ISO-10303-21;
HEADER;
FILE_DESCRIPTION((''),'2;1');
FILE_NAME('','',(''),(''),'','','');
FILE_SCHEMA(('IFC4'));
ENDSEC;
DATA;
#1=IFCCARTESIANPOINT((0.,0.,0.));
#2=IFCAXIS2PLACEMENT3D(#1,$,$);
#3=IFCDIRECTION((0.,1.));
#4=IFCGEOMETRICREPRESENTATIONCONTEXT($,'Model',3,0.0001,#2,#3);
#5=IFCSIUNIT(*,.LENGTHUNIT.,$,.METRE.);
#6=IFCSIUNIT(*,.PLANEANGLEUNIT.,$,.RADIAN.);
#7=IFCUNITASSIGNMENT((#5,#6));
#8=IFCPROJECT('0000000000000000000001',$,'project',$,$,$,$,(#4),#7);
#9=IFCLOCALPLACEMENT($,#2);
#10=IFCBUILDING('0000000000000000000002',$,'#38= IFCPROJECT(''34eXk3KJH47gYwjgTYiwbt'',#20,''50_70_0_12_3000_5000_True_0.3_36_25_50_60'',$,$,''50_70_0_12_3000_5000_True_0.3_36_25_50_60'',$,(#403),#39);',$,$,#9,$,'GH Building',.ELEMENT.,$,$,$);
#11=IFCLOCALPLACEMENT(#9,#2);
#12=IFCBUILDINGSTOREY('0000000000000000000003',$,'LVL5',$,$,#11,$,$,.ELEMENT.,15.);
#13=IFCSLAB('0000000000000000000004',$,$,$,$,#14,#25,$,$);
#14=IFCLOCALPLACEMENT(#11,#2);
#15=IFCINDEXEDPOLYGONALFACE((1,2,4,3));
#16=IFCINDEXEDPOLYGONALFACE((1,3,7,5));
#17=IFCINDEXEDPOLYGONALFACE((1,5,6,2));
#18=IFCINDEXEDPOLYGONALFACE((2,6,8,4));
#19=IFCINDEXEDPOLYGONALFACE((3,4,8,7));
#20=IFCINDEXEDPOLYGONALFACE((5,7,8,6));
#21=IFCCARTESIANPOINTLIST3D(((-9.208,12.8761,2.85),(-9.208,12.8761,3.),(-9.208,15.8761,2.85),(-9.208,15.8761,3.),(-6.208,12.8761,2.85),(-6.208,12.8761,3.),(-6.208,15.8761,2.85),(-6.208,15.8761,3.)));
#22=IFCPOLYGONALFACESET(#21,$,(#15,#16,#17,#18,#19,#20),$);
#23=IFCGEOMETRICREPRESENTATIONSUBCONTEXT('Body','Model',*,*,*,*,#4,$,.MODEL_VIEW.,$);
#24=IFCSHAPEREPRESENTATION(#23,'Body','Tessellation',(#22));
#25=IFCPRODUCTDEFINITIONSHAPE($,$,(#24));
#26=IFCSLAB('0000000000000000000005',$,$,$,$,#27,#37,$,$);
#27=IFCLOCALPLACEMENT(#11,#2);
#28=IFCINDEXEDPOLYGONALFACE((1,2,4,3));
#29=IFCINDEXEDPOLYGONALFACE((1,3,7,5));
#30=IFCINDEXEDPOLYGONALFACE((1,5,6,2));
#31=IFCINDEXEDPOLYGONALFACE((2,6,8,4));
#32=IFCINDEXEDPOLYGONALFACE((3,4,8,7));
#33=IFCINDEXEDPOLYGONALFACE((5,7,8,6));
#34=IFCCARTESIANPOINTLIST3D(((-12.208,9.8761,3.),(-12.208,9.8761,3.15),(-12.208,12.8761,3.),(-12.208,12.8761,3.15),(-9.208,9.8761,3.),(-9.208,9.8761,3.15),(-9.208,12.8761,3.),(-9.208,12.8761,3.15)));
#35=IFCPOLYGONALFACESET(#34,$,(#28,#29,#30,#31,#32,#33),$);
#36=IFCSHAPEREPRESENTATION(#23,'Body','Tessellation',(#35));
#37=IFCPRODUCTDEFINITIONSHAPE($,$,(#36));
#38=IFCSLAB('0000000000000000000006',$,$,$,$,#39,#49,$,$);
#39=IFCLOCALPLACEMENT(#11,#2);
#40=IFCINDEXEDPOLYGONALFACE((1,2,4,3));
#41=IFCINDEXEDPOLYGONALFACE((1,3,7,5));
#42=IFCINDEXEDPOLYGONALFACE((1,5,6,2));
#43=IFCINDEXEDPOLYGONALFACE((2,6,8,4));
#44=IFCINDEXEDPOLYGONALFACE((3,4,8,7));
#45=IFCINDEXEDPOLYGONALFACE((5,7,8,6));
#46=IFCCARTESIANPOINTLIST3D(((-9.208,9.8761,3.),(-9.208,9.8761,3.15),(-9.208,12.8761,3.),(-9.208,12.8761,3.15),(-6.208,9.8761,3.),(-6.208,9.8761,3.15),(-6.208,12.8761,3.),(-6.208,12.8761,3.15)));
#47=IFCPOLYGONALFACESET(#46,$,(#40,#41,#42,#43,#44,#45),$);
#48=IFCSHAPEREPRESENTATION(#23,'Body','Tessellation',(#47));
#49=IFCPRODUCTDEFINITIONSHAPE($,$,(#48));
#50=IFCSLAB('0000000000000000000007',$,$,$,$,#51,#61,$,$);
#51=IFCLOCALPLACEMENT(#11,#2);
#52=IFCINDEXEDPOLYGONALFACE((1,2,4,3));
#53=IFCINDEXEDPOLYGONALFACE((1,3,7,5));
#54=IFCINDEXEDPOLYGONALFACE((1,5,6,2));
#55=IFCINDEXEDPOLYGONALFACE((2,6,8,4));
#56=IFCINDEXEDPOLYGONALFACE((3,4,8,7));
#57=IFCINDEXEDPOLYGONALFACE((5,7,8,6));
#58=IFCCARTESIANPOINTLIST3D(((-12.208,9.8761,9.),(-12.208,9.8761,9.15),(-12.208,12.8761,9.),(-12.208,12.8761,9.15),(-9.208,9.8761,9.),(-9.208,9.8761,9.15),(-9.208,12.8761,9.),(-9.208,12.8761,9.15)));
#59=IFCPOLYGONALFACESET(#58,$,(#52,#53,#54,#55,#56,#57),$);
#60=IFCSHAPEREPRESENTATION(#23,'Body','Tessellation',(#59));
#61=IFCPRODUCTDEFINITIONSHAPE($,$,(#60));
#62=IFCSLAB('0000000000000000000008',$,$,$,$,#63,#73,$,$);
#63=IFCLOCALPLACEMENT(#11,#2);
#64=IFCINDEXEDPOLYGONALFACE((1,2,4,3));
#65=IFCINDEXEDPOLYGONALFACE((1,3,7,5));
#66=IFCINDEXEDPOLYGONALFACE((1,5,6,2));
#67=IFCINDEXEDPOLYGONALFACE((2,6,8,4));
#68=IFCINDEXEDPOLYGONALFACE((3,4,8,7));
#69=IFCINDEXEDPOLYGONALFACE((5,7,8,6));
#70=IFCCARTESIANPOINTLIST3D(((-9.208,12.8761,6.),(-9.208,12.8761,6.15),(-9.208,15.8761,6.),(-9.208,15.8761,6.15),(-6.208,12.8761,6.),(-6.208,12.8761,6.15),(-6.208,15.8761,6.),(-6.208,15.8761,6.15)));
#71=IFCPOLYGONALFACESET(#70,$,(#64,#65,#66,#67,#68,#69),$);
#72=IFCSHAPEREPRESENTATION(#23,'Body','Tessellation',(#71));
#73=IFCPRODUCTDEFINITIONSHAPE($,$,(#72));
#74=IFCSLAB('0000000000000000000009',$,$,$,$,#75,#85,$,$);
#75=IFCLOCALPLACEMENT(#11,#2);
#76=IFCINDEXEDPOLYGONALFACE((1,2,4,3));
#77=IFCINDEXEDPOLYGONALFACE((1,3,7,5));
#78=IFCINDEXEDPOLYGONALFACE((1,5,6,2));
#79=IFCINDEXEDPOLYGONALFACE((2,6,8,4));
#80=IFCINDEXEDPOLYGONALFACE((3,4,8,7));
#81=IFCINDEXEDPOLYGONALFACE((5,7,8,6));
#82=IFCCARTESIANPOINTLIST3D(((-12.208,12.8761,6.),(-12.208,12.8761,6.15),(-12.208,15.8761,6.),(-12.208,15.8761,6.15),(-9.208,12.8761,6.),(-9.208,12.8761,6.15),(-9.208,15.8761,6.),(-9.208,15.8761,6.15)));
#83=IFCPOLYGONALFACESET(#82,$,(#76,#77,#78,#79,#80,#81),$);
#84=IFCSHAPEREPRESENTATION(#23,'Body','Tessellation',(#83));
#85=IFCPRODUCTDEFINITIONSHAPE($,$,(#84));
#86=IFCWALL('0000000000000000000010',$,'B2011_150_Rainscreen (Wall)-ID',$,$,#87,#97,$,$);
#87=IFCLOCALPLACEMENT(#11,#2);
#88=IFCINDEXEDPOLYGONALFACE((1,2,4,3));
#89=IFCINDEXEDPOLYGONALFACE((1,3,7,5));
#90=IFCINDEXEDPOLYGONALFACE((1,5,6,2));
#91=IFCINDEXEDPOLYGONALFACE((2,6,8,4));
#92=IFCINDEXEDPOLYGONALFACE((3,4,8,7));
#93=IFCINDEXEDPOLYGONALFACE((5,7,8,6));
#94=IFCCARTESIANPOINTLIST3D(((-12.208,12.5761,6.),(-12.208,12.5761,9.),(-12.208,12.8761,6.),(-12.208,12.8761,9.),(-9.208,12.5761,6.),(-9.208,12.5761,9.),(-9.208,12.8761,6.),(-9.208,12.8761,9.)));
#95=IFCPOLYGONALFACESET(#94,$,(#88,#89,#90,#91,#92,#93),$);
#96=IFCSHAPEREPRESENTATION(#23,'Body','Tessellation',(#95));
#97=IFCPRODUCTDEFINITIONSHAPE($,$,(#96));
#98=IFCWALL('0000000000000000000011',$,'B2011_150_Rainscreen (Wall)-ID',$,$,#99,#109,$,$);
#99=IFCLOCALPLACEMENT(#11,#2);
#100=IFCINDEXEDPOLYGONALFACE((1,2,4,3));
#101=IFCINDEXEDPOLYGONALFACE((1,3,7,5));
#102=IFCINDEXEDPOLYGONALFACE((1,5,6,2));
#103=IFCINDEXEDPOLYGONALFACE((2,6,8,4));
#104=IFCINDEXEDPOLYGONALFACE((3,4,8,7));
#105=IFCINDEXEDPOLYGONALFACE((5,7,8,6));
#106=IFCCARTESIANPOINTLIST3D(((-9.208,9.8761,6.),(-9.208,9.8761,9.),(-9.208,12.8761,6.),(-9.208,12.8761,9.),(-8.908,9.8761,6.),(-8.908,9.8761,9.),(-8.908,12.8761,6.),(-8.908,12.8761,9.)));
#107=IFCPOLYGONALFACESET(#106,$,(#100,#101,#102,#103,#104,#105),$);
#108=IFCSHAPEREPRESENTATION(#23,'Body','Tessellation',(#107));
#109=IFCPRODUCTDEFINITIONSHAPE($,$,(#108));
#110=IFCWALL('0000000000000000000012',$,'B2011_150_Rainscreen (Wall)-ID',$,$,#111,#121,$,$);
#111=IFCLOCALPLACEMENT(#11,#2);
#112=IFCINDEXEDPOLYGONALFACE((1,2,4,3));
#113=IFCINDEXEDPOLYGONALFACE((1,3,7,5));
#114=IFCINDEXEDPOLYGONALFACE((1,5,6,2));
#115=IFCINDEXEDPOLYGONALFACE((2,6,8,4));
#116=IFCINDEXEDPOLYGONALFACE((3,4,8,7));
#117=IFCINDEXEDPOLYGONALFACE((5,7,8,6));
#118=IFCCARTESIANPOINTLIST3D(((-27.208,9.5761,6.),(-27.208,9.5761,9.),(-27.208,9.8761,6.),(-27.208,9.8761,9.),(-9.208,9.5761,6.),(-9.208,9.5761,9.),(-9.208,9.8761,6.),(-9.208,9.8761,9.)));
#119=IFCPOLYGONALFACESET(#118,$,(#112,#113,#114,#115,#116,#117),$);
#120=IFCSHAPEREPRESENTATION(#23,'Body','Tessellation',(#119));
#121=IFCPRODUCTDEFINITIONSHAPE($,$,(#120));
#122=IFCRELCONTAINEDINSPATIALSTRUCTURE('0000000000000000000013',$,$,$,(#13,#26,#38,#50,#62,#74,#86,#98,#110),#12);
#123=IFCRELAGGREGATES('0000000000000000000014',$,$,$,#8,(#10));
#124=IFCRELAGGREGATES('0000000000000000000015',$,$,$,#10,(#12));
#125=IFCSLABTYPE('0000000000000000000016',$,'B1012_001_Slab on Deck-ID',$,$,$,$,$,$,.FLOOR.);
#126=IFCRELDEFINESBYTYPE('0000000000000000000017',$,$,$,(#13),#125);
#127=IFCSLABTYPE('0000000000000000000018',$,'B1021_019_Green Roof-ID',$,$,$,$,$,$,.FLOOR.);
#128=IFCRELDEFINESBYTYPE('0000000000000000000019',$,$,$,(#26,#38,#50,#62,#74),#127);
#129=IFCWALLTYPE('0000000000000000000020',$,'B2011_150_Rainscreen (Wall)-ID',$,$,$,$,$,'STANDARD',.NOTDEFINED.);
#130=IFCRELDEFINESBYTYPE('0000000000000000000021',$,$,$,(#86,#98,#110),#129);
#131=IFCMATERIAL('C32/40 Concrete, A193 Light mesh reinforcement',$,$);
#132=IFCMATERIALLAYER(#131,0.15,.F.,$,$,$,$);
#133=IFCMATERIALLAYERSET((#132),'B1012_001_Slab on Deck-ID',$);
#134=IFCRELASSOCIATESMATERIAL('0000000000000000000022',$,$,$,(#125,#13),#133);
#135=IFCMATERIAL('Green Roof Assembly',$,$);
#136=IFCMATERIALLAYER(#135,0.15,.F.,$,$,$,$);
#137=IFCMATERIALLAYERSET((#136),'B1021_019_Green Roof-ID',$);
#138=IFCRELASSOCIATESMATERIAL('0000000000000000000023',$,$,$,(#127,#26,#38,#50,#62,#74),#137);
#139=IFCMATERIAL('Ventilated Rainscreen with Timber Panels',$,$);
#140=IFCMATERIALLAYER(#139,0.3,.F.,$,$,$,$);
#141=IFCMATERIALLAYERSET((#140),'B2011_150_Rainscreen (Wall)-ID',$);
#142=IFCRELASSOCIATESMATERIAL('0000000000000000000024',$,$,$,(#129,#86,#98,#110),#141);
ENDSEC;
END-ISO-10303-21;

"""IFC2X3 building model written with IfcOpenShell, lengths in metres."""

from ifc_helpers import new_model, si_unit, direction, frame, frame_2d, origin, place, context, subcontext, project, spatial, polyline, rectangle, outline, extrude, material, layer, layer_set, layer_usage, type_object, element, save


model = new_model("IFC2X3")

# Units and contexts
model_context = context("Model", 3, precision=0.0001, world=origin(), true_north=direction((0.0, 1.0)))
body_context = subcontext(model_context, "Body", "Model", "MODEL_VIEW")
ifc_project = project(units=[si_unit("LENGTHUNIT", "METRE"), si_unit("PLANEANGLEUNIT", "RADIAN")], contexts=[model_context])

# Building, storey
building_placement = place(None, origin())
building = spatial("IfcBuilding", under=ifc_project, at=building_placement, Name="#38= IFCPROJECT('34eXk3KJH47gYwjgTYiwbt',#20,'50_70_0_12_3000_5000_True_0.3_36_25_50_60',$,$,'50_70_0_12_3000_5000_True_0.3_36_25_50_60',$,(#403),#39);", LongName="GH Building", CompositionType="ELEMENT")
storey_placement = place(building_placement, origin())
storey = spatial("IfcBuildingStorey", under=building, at=storey_placement, Name="LVL5", CompositionType="ELEMENT", Elevation=15.0)

# Slabs
ifc_material_1 = material(Name="C32/40 Concrete, A193 Light mesh reinforcement")
ifc_layer_1 = layer(ifc_material_1, 0.15, ventilated=False)
ifc_layer_set_1 = layer_set([ifc_layer_1], Name="B1012_001_Slab on Deck-ID")
slab_type_1 = type_object("IfcSlabType", Name="B1012_001_Slab on Deck-ID", PredefinedType="FLOOR", material=ifc_layer_set_1)
ifc_layer_usage_1 = layer_usage(ifc_layer_set_1, "AXIS3", "NEGATIVE", -0.15)
slab_1_placement = place(storey_placement, frame((-7.708, 14.3761, 2.85), z_axis=(0.0, 0.0, 1.0), x_axis=(0.0, 1.0, 0.0)))
element("IfcSlab", 1, at=slab_1_placement, inside=storey, type_object=slab_type_1, material=ifc_layer_usage_1, context=body_context, shape_type="SweptSolid", body=[
    extrude(outline(polyline([(-1.5, -1.5), (1.5, -1.5), (1.5, 1.5), (-1.5, 1.5), (-1.5, -1.5)])), origin(), (0.0, 0.0, 1.0), 0.15),
])
ifc_material_2 = material(Name="Green Roof Assembly")
ifc_layer_2 = layer(ifc_material_2, 0.15, ventilated=False)
ifc_layer_set_2 = layer_set([ifc_layer_2], Name="B1021_019_Green Roof-ID")
ifc_layer_usage_2 = layer_usage(ifc_layer_set_2, "AXIS3", "NEGATIVE", -0.15)
slab_type_2 = type_object("IfcSlabType", Name="B1021_019_Green Roof-ID", PredefinedType="FLOOR", material=ifc_layer_set_2)
slab_2_placement = place(storey_placement, frame((-10.708, 11.3761, 3.0), z_axis=(0.0, 0.0, 1.0), x_axis=(0.0, 1.0, 0.0)))
element("IfcSlab", 2, at=slab_2_placement, inside=storey, type_object=slab_type_2, material=ifc_layer_usage_2, context=body_context, shape_type="SweptSolid", body=[
    extrude(outline(polyline([(-1.5, -1.5), (1.5, -1.5), (1.5, 1.5), (-1.5, 1.5), (-1.5, -1.5)])), origin(), (0.0, 0.0, 1.0), 0.15),
])
ifc_layer_usage_3 = layer_usage(ifc_layer_set_2, "AXIS3", "NEGATIVE", -0.15)
slab_3_placement = place(storey_placement, frame((-7.708, 11.3761, 3.0), z_axis=(0.0, 0.0, 1.0), x_axis=(0.0, 1.0, 0.0)))
element("IfcSlab", 3, at=slab_3_placement, inside=storey, type_object=slab_type_2, material=ifc_layer_usage_3, context=body_context, shape_type="SweptSolid", body=[
    extrude(outline(polyline([(-1.5, -1.5), (1.5, -1.5), (1.5, 1.5), (-1.5, 1.5), (-1.5, -1.5)])), origin(), (0.0, 0.0, 1.0), 0.15),
])
ifc_layer_usage_4 = layer_usage(ifc_layer_set_2, "AXIS3", "NEGATIVE", -0.15)
slab_4_placement = place(storey_placement, frame((-10.708, 11.3761, 9.0)))
element("IfcSlab", 4, at=slab_4_placement, inside=storey, type_object=slab_type_2, material=ifc_layer_usage_4, context=body_context, shape_type="SweptSolid", body=[
    extrude(outline(polyline([(1.5, -1.5), (-1.5, -1.5), (-1.5, 1.5), (1.5, 1.5), (1.5, -1.5)])), origin(), (0.0, 0.0, 1.0), 0.15),
])
ifc_layer_usage_5 = layer_usage(ifc_layer_set_2, "AXIS3", "NEGATIVE", -0.15)
slab_5_placement = place(storey_placement, frame((-7.708, 14.3761, 6.0)))
element("IfcSlab", 5, at=slab_5_placement, inside=storey, type_object=slab_type_2, material=ifc_layer_usage_5, context=body_context, shape_type="SweptSolid", body=[
    extrude(outline(polyline([(-1.5, 1.5), (1.5, 1.5), (1.5, -1.5), (-1.5, -1.5), (-1.5, 1.5)])), origin(), (0.0, 0.0, 1.0), 0.15),
])
ifc_layer_usage_6 = layer_usage(ifc_layer_set_2, "AXIS3", "NEGATIVE", -0.15)
slab_6_placement = place(storey_placement, frame((-10.708, 14.3761, 6.0)))
element("IfcSlab", 6, at=slab_6_placement, inside=storey, type_object=slab_type_2, material=ifc_layer_usage_6, context=body_context, shape_type="SweptSolid", body=[
    extrude(outline(polyline([(1.5, -1.5), (-1.5, -1.5), (-1.5, 1.5), (1.5, 1.5), (1.5, -1.5)])), origin(), (0.0, 0.0, 1.0), 0.15),
])

# Walls
ifc_material_3 = material(Name="Ventilated Rainscreen with Timber Panels")
ifc_layer_3 = layer(ifc_material_3, 0.3, ventilated=False)
ifc_layer_set_3 = layer_set([ifc_layer_3], Name="B2011_150_Rainscreen (Wall)-ID")
ifc_layer_usage_7 = layer_usage(ifc_layer_set_3, "AXIS2", "POSITIVE", 0.0)
wall_type = type_object("IfcWallType", Name="B2011_150_Rainscreen (Wall)-ID", ElementType="STANDARD", PredefinedType="NOTDEFINED", material=ifc_layer_set_3)
wall_1_placement = place(storey_placement, frame((-9.208, 12.8761, 6.0), z_axis=(0.0, 0.0, 1.0), x_axis=(-1.0, 0.0, 0.0)))
element("IfcWall", 7, at=wall_1_placement, inside=storey, type_object=wall_type, material=ifc_layer_usage_7, Name="B2011_150_Rainscreen (Wall)-ID", context=body_context, shape_type="SweptSolid", body=[
    extrude(rectangle(XDim=3.0, YDim=0.3, at=frame_2d((1.5, 0.15))), origin(), (0.0, 0.0, 1.0), 3.0),
])
ifc_layer_usage_8 = layer_usage(ifc_layer_set_3, "AXIS2", "POSITIVE", 0.0)
wall_2_placement = place(storey_placement, frame((-9.208, 12.8761, 6.0), z_axis=(0.0, 0.0, 1.0), x_axis=(0.0, -1.0, 0.0)))
element("IfcWall", 8, at=wall_2_placement, inside=storey, type_object=wall_type, material=ifc_layer_usage_8, Name="B2011_150_Rainscreen (Wall)-ID", context=body_context, shape_type="SweptSolid", body=[
    extrude(rectangle(XDim=3.0, YDim=0.3, at=frame_2d((1.5, 0.15))), origin(), (0.0, 0.0, 1.0), 3.0),
])
ifc_layer_usage_9 = layer_usage(ifc_layer_set_3, "AXIS2", "POSITIVE", 0.0)
wall_3_placement = place(storey_placement, frame((-9.208, 9.8761, 6.0), z_axis=(0.0, 0.0, 1.0), x_axis=(-1.0, 0.0, 0.0)))
element("IfcWall", 9, at=wall_3_placement, inside=storey, type_object=wall_type, material=ifc_layer_usage_9, Name="B2011_150_Rainscreen (Wall)-ID", context=body_context, shape_type="SweptSolid", body=[
    extrude(rectangle(XDim=18.0, YDim=0.3, at=frame_2d((9.0, 0.15))), origin(), (0.0, 0.0, 1.0), 3.0),
])

save(model, "model.ifc")
